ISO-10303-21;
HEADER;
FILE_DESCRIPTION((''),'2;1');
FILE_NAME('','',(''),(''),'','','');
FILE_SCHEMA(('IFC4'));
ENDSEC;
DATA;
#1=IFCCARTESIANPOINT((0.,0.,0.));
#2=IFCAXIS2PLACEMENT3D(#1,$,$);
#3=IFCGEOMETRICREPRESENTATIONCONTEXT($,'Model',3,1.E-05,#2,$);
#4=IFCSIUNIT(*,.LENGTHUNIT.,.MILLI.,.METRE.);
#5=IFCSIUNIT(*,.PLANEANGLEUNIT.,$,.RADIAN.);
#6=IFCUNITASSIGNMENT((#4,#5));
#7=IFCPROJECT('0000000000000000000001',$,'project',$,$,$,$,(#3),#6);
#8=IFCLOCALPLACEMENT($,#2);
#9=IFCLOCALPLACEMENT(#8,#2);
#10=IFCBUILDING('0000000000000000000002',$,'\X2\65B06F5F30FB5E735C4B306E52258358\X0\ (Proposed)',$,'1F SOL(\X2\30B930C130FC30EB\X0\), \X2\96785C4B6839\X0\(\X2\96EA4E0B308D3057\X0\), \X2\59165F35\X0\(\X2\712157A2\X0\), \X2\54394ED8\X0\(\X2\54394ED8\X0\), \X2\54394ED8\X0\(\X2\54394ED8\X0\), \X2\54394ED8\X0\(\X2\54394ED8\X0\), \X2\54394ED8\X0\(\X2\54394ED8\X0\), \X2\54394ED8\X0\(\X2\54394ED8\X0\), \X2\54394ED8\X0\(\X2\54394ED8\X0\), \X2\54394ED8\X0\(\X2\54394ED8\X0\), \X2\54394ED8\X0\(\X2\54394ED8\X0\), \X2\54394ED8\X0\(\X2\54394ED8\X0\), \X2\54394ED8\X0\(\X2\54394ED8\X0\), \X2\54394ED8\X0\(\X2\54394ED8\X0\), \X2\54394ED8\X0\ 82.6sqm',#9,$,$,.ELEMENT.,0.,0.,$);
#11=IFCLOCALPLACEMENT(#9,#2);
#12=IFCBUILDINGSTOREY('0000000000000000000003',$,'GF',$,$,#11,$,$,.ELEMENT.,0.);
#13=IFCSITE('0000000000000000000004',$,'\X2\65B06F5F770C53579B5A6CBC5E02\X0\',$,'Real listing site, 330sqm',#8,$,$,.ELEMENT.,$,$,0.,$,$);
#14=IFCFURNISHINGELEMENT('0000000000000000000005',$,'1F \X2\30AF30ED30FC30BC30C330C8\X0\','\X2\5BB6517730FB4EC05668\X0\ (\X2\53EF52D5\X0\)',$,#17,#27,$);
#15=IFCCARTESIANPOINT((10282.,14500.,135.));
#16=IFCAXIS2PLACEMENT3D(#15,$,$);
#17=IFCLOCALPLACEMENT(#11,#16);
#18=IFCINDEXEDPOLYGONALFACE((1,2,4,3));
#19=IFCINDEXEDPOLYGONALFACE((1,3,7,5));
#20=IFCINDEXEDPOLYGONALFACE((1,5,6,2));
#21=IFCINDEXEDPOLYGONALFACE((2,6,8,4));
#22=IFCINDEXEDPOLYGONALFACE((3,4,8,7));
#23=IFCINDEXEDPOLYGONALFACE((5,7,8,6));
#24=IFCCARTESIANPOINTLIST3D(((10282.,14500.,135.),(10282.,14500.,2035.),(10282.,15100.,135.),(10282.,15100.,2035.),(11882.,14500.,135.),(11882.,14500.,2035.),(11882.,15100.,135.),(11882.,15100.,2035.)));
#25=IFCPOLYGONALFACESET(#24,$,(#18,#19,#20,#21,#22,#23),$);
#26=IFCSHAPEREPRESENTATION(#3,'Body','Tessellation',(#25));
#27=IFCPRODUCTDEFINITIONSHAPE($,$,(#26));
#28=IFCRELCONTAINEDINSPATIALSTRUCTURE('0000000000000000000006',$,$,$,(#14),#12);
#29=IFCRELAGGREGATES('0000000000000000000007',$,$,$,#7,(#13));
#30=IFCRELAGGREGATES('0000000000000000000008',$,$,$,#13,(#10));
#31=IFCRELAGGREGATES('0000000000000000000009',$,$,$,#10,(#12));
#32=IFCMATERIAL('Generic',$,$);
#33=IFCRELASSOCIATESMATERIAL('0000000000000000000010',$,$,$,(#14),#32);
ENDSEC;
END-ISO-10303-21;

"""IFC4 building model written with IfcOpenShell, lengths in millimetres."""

from ifc_helpers import new_model, si_unit, frame, frame_2d, origin, place, context, project, spatial, rectangle, extrude, material, element, save


model = new_model("IFC4")

# Units and contexts
model_context = context("Model", 3, precision=1e-05, world=origin())
ifc_project = project(units=[si_unit("LENGTHUNIT", "METRE", prefix="MILLI"), si_unit("PLANEANGLEUNIT", "RADIAN")], contexts=[model_context])

# Site, building, storey
site_placement = place(None, origin())
site = spatial("IfcSite", under=ifc_project, at=site_placement, Name="新潟県南魚沼市", ObjectType="Real listing site, 330sqm", CompositionType="ELEMENT", RefElevation=0.0)
building_placement = place(site_placement, origin())
building = spatial("IfcBuilding", under=site, at=building_placement, Name="新潟・平屋の別荘 (Proposed)", ObjectType="1F SOL(スチール), 陸屋根(雪下ろし), 外張(無垢), 吹付(吹付), 吹付(吹付), 吹付(吹付), 吹付(吹付), 吹付(吹付), 吹付(吹付), 吹付(吹付), 吹付(吹付), 吹付(吹付), 吹付(吹付), 吹付(吹付), 吹付 82.6sqm", CompositionType="ELEMENT", ElevationOfRefHeight=0.0, ElevationOfTerrain=0.0)
storey_placement = place(building_placement, origin())
storey = spatial("IfcBuildingStorey", under=building, at=storey_placement, Name="GF", CompositionType="ELEMENT", Elevation=0.0)

# Shared definitions
ifc_material_1 = material(Name="Generic")

# Furnishing element
furnishing_placement = place(storey_placement, frame((10282.0, 14500.0, 135.0)))
element("IfcFurnishingElement", 1, at=furnishing_placement, inside=storey, material=ifc_material_1, Name="1F クローゼット", Description="家具・什器 (可動)", context=model_context, shape_type="SweptSolid", body=[
    extrude(rectangle(XDim=1600.0, YDim=600.0, at=frame_2d((800.0, 300.0))), frame((10282.0, 14500.0, 135.0)), (0.0, 0.0, 1.0), 1900.0),
])

save(model, "model.ifc")
